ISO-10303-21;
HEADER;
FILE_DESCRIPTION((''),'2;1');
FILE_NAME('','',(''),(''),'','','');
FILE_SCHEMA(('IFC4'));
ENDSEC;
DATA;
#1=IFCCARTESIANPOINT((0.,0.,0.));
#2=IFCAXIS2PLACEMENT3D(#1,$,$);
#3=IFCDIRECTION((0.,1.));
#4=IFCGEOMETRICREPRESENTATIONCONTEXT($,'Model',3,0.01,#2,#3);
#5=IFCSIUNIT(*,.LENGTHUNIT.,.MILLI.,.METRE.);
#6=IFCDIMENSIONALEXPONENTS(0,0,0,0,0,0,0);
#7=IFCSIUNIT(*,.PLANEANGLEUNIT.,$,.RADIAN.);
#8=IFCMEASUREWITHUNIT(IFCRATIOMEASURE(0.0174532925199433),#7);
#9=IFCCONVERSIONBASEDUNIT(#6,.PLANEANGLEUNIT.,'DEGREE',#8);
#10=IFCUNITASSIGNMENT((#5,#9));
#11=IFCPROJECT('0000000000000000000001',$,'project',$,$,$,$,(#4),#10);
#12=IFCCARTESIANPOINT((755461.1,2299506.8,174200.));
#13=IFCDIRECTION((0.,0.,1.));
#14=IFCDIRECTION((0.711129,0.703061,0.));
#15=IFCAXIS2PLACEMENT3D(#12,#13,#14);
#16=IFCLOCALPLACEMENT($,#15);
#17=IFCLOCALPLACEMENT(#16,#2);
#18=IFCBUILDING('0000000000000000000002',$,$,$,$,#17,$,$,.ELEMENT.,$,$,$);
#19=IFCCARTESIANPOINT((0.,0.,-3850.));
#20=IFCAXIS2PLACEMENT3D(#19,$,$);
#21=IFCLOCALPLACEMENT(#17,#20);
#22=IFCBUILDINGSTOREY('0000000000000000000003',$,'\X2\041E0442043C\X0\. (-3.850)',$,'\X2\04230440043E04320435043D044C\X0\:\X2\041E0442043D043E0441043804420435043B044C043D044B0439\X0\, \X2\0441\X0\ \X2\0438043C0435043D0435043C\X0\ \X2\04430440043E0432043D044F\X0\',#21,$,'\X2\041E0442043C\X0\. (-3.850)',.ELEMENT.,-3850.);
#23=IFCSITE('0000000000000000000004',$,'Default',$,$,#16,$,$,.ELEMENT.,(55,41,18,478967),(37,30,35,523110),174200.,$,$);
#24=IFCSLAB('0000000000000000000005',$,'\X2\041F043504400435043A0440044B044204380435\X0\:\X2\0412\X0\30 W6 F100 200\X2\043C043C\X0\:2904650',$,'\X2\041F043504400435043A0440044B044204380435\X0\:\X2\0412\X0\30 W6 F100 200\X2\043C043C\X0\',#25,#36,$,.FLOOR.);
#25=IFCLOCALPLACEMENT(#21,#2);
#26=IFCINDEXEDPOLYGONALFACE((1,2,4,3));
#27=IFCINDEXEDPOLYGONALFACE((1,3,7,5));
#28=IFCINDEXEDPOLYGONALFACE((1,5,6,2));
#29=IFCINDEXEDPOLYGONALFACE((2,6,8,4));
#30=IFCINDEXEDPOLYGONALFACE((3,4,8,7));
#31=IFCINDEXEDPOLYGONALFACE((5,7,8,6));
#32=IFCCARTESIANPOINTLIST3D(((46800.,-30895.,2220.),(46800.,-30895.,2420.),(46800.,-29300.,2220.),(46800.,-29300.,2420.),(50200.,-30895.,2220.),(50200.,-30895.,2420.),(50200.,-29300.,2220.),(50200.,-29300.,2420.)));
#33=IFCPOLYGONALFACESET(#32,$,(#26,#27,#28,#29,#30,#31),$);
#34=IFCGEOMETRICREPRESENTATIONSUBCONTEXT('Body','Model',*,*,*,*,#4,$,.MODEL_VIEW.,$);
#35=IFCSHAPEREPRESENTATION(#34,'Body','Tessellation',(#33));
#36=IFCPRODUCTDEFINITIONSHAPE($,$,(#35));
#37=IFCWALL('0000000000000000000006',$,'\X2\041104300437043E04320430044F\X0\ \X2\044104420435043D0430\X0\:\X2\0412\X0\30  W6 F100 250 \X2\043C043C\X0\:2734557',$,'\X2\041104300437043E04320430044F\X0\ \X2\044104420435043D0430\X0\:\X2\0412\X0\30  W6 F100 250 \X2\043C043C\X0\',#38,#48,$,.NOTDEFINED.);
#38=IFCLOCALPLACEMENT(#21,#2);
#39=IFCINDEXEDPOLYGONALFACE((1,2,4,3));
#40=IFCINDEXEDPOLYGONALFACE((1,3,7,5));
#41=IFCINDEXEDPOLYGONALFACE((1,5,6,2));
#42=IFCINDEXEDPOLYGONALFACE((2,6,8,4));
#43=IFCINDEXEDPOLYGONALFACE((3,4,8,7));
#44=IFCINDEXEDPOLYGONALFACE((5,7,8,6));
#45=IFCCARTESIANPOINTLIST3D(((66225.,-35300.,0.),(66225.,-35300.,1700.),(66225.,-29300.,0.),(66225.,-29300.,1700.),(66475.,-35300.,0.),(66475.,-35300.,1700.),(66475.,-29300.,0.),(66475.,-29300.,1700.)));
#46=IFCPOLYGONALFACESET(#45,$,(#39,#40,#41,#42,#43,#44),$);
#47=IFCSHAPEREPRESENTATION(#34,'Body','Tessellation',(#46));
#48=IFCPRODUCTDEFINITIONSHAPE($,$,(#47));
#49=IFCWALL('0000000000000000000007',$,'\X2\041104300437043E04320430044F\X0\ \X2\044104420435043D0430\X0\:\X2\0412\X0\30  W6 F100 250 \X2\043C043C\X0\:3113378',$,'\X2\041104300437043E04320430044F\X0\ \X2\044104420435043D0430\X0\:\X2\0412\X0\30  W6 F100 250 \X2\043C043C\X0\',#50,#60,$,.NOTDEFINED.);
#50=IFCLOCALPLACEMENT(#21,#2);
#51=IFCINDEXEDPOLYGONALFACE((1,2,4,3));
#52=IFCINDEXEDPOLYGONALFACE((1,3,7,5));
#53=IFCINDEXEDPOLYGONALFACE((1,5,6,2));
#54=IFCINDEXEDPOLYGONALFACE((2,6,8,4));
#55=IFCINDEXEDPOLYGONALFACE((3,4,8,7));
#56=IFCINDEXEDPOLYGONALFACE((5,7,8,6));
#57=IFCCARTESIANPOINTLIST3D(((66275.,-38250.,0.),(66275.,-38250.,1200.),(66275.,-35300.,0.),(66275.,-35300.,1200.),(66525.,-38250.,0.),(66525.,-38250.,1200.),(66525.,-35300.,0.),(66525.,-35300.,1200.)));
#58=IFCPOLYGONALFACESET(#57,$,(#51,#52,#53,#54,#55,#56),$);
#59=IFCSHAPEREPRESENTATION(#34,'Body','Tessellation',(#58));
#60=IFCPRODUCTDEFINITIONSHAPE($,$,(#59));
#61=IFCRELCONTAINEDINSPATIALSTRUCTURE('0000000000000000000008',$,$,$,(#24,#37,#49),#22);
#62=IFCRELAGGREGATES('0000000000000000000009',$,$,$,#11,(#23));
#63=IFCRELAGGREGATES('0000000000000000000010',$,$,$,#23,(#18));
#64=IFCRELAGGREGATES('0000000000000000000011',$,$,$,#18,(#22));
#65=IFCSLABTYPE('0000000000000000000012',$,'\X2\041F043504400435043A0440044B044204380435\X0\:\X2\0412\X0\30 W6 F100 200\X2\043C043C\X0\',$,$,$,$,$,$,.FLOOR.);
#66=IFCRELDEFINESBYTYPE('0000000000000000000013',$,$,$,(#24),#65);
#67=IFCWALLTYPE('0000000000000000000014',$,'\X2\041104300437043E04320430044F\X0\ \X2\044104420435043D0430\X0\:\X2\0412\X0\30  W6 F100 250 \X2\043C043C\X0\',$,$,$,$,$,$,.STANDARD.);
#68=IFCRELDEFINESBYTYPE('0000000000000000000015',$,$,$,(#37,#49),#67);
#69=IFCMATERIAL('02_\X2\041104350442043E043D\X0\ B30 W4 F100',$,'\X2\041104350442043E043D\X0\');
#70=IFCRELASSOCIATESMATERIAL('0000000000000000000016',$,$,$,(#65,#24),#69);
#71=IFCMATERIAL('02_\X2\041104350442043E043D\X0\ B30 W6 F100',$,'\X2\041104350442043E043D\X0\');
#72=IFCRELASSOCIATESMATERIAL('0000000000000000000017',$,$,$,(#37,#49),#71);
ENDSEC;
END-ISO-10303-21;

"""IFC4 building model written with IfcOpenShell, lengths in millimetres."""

from ifc_helpers import new_model, entity, si_unit, converted_unit, direction, frame, origin, place, context, subcontext, project, spatial, indexed_curve, outline, extrude, material, type_object, element, save


model = new_model("IFC4")

# Units and contexts
model_context = context("Model", 3, precision=0.01, world=origin(), true_north=direction((0.0, 1.0)))
body_context = subcontext(model_context, "Body", "Model", "MODEL_VIEW")
ifc_project = project(units=[si_unit("LENGTHUNIT", "METRE", prefix="MILLI"), converted_unit("PLANEANGLEUNIT", "DEGREE", entity("IfcRatioMeasure", 0.0174532925199433), si_unit("PLANEANGLEUNIT", "RADIAN"), dimensions=[0, 0, 0, 0, 0, 0, 0])], contexts=[model_context])

# Site, building, storey
site_placement = place(None, frame((755461.1, 2299506.8, 174200.0), z_axis=(0.0, 0.0, 1.0), x_axis=(0.711129, 0.703061, 0.0)))
site = spatial("IfcSite", under=ifc_project, at=site_placement, Name="Default", CompositionType="ELEMENT", RefLatitude=(55, 41, 18, 478967), RefLongitude=(37, 30, 35, 523110), RefElevation=174200.0)
building_placement = place(site_placement, origin())
building = spatial("IfcBuilding", under=site, at=building_placement, CompositionType="ELEMENT")
storey_placement = place(building_placement, frame((0.0, 0.0, -3850.0)))
storey = spatial("IfcBuildingStorey", under=building, at=storey_placement, Name="Отм. (-3.850)", ObjectType="Уровень:Относительный, с именем уровня", LongName="Отм. (-3.850)", CompositionType="ELEMENT", Elevation=-3850.0)

# Slab
ifc_material_1 = material(Name="02_Бетон B30 W6 F100", Category="Бетон")
ifc_material_2 = material(Name="02_Бетон B30 W4 F100", Category="Бетон")
slab_type_1 = type_object("IfcSlabType", Name="Перекрытие:В30 W6 F100 200мм", PredefinedType="FLOOR", material=ifc_material_2)
slab_1_placement = place(storey_placement, origin())
element("IfcSlab", 1, at=slab_1_placement, inside=storey, type_object=slab_type_1, material=ifc_material_2, Name="Перекрытие:В30 W6 F100 200мм:2904650", ObjectType="Перекрытие:В30 W6 F100 200мм", PredefinedType="FLOOR", context=body_context, shape_type="SweptSolid", body=[
    extrude(outline(indexed_curve([(-797.5, -1700.0), (797.5, -1700.0), (797.5, 1700.0), (-797.5, 1700.0), (-797.5, -1700.0)], self_intersect=False)), frame((48500.0, -30097.5, 2420.0), z_axis=(0.0, 0.0, -1.0), x_axis=(0.0, 1.0, 0.0)), (0.0, 0.0, 1.0), 200.0),
])

# Walls
wall_type = type_object("IfcWallType", Name="Базовая стена:В30  W6 F100 250 мм", PredefinedType="STANDARD")
wall_1_placement = place(storey_placement, frame((66350.0, -29300.0, 0.0), z_axis=(0.0, 0.0, 1.0), x_axis=(0.0, -1.0, 0.0)))
element("IfcWall", 2, at=wall_1_placement, inside=storey, type_object=wall_type, material=ifc_material_1, Name="Базовая стена:В30  W6 F100 250 мм:2734557", ObjectType="Базовая стена:В30  W6 F100 250 мм", PredefinedType="NOTDEFINED", context=body_context, shape_type="SweptSolid", body=[
    extrude(outline(indexed_curve([(6000.0, 125.0), (0.0, 125.0), (0.0, -125.0), (6000.0, -125.0), (6000.0, 125.0)], self_intersect=False)), origin(), (0.0, 0.0, 1.0), 1700.0),
])
wall_2_placement = place(storey_placement, frame((66400.0, -35300.0, 0.0), z_axis=(0.0, 0.0, 1.0), x_axis=(0.0, -1.0, 0.0)))
element("IfcWall", 3, at=wall_2_placement, inside=storey, type_object=wall_type, material=ifc_material_1, Name="Базовая стена:В30  W6 F100 250 мм:3113378", ObjectType="Базовая стена:В30  W6 F100 250 мм", PredefinedType="NOTDEFINED", context=body_context, shape_type="SweptSolid", body=[
    extrude(outline(indexed_curve([(2950.0, 125.0), (0.0, 125.0), (0.0, -125.0), (2950.0, -125.0), (2950.0, 125.0)], self_intersect=False)), origin(), (0.0, 0.0, 1.0), 1200.0),
])

save(model, "model.ifc")
